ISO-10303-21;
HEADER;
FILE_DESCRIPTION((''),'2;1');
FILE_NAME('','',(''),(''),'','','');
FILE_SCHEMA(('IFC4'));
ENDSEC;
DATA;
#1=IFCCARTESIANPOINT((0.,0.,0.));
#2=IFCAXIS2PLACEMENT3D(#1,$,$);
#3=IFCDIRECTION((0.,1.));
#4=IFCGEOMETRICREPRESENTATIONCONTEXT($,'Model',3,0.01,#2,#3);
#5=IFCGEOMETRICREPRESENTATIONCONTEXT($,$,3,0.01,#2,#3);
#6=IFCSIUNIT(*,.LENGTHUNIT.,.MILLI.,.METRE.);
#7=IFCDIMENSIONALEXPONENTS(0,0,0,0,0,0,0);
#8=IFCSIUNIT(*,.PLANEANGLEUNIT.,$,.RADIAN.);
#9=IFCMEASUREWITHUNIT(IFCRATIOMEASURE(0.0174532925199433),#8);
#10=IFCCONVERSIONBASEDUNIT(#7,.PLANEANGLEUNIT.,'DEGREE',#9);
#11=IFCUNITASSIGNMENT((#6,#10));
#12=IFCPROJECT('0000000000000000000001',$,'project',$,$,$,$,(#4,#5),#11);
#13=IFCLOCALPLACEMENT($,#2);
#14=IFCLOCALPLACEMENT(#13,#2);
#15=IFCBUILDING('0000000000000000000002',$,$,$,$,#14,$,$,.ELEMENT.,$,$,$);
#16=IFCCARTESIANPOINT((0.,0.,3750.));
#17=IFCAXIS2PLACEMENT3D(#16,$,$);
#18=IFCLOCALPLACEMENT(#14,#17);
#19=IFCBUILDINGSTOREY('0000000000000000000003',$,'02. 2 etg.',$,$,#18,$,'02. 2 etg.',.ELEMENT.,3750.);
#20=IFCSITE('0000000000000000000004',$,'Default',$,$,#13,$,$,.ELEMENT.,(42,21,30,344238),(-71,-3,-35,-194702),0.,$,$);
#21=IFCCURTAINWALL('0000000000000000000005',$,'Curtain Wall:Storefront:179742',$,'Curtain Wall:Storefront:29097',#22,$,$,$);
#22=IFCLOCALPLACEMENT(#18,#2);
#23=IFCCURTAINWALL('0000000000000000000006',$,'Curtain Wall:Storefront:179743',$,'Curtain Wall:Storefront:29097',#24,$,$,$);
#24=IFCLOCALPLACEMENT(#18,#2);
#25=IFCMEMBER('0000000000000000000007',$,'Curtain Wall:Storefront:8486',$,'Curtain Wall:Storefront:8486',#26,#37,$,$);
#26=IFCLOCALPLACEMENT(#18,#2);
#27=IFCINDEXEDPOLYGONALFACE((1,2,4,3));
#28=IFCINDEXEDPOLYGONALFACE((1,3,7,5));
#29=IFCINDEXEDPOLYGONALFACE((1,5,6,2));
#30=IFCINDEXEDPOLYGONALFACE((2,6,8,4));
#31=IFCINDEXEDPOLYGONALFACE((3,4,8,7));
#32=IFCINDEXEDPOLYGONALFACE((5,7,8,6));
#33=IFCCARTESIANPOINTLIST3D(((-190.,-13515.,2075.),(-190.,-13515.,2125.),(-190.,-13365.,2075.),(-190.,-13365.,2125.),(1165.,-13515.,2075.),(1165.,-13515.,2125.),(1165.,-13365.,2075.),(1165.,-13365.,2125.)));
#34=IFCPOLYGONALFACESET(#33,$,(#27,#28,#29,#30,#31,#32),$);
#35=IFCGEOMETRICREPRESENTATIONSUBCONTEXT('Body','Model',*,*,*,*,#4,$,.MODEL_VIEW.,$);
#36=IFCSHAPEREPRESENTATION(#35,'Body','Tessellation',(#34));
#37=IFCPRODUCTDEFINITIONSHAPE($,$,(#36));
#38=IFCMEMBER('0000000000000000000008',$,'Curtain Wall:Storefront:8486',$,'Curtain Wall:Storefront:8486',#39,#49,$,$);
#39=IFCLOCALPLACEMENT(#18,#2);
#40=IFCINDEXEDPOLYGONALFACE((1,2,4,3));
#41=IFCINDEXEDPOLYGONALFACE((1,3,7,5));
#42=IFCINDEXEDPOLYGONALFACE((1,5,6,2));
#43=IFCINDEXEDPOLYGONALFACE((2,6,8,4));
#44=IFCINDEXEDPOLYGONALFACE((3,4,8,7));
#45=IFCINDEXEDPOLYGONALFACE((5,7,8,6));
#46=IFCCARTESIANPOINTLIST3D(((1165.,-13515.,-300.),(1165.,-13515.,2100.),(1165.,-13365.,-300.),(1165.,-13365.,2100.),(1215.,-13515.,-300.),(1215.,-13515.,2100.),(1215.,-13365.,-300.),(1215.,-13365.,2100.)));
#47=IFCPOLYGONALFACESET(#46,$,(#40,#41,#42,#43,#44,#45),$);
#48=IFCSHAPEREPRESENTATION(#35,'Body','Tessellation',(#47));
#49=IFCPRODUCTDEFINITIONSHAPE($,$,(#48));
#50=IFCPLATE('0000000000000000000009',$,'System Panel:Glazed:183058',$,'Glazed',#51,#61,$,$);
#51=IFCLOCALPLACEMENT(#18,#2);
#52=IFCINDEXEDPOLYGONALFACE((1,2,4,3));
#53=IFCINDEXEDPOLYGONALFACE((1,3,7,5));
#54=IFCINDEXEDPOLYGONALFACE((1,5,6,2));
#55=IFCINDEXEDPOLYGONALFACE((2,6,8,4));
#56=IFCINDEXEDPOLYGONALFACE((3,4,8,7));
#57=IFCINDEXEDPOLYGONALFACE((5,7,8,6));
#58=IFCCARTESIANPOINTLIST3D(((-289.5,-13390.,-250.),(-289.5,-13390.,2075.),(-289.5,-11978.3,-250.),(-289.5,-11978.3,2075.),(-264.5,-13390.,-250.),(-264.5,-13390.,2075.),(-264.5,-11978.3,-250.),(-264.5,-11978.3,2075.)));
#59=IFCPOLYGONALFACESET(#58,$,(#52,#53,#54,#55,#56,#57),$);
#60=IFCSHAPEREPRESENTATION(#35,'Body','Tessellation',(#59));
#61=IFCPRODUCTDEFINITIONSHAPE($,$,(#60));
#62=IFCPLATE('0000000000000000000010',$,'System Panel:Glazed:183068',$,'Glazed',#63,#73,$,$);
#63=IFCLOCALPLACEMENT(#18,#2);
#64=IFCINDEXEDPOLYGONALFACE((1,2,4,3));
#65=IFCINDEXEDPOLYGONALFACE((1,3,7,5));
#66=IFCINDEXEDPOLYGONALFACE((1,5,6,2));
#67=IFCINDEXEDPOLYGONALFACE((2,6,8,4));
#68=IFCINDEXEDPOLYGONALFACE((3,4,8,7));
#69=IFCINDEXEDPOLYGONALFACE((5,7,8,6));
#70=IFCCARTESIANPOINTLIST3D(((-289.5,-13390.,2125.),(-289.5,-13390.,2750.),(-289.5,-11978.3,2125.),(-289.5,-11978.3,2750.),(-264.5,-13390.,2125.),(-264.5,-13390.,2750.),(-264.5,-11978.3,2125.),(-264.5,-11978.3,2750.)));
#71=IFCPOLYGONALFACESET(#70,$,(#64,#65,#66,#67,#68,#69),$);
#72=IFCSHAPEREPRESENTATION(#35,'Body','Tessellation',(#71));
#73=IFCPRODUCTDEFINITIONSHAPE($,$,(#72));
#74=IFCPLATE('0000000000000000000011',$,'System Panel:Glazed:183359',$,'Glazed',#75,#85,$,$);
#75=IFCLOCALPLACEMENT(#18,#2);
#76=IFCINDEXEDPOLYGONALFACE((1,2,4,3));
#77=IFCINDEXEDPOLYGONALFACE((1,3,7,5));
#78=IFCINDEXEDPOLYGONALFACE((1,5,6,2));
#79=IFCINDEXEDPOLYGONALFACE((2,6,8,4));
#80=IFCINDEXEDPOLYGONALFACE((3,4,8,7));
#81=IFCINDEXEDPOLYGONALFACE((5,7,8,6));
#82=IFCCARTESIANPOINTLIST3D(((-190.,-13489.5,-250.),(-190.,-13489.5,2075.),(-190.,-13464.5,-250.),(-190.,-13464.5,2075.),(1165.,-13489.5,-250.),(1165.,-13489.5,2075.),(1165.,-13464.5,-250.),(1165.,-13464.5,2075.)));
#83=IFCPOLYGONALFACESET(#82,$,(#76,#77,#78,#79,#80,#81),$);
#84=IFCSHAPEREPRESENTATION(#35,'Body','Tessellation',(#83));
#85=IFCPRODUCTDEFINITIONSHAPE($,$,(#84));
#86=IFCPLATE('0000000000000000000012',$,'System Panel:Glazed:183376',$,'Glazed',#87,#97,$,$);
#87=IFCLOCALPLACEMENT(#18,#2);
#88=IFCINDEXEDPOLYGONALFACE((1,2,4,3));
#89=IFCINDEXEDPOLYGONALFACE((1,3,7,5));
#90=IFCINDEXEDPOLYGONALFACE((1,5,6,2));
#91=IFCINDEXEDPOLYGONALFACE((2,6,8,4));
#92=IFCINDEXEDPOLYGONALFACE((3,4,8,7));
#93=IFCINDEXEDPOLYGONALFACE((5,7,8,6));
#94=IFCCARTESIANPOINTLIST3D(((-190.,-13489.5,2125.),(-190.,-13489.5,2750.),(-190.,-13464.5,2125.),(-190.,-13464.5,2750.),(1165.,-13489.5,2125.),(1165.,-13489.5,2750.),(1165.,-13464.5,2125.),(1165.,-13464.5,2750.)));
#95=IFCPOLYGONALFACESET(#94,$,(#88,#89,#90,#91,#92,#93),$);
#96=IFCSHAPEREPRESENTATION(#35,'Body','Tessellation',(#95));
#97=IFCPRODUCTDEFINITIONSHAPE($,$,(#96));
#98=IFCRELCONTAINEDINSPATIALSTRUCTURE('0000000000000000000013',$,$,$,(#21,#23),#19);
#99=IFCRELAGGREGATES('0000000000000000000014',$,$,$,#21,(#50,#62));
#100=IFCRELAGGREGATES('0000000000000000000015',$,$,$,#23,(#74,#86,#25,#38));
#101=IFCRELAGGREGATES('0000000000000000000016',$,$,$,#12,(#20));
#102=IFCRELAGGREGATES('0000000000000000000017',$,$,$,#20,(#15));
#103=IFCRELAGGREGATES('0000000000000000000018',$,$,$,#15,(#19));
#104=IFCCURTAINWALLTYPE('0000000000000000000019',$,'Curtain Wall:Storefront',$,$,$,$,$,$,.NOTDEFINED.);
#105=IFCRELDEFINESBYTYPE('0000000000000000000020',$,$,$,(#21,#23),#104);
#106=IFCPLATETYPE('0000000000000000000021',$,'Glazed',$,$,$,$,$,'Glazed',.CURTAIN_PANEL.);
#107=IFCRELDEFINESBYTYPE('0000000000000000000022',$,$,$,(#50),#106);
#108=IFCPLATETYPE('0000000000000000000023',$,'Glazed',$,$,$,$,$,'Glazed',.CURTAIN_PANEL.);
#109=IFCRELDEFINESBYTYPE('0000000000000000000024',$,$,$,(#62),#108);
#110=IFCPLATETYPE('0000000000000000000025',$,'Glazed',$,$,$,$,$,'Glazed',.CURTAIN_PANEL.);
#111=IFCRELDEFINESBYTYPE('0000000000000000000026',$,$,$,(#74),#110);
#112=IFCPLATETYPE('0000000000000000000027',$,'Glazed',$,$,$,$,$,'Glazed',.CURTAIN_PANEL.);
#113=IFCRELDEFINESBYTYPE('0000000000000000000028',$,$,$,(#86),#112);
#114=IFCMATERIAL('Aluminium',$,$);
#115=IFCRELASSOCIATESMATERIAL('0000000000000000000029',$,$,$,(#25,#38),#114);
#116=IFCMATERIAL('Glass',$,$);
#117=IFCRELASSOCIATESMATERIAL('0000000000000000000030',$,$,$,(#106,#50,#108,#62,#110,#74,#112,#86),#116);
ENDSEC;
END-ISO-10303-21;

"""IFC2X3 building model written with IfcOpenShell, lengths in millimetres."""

from ifc_helpers import new_model, entity, si_unit, converted_unit, direction, frame, frame_2d, origin, origin_2d_with_axis, place, context, subcontext, project, spatial, rectangle, extrude, source, transform, mapped, material, type_object, type_shapes, element, aggregate, save


model = new_model("IFC2X3")

# Units and contexts
model_context = context("Model", 3, precision=0.01, world=origin(), true_north=direction((0.0, 1.0)))
context_of_model = context(None, 3, precision=0.01, world=origin(), true_north=direction((0.0, 1.0)))
body_context = subcontext(model_context, "Body", "Model", "MODEL_VIEW")
ifc_project = project(units=[si_unit("LENGTHUNIT", "METRE", prefix="MILLI"), converted_unit("PLANEANGLEUNIT", "DEGREE", entity("IfcRatioMeasure", 0.0174532925199433), si_unit("PLANEANGLEUNIT", "RADIAN"), dimensions=[0, 0, 0, 0, 0, 0, 0])], contexts=[model_context, context_of_model])

# Site, building, storey
site_placement = place(None, origin())
site = spatial("IfcSite", under=ifc_project, at=site_placement, Name="Default", CompositionType="ELEMENT", RefLatitude=(42, 21, 30, 344238), RefLongitude=(-71, -3, -35, -194702), RefElevation=0.0)
building_placement = place(site_placement, origin())
building = spatial("IfcBuilding", under=site, at=building_placement, CompositionType="ELEMENT")
storey_placement = place(building_placement, frame((0.0, 0.0, 3750.0)))
storey = spatial("IfcBuildingStorey", under=building, at=storey_placement, Name="02. 2 etg.", LongName="02. 2 etg.", CompositionType="ELEMENT", Elevation=3750.0)

# Curtain walls, members
curtain_wall_type = type_object("IfcCurtainWallType", Name="Curtain Wall:Storefront", PredefinedType="NOTDEFINED")
curtain_wall_1_placement = place(storey_placement, frame((0.0, 0.0, -3750.0)))
curtain_wall_1 = element("IfcCurtainWall", 1, at=curtain_wall_1_placement, inside=storey, type_object=curtain_wall_type, Name="Curtain Wall:Storefront:179742", ObjectType="Curtain Wall:Storefront:29097")
ifc_material_1 = material(Name="Aluminium")
curtain_wall_2_placement = place(storey_placement, frame((0.0, 0.0, -3750.0)))
curtain_wall_2 = element("IfcCurtainWall", 2, at=curtain_wall_2_placement, inside=storey, type_object=curtain_wall_type, Name="Curtain Wall:Storefront:179743", ObjectType="Curtain Wall:Storefront:29097")
member_1_placement = place(curtain_wall_2_placement, frame((-190.0, -13515.0, 5825.0)))
member_1 = element("IfcMember", 3, at=member_1_placement, material=ifc_material_1, Name="Curtain Wall:Storefront:8486", ObjectType="Curtain Wall:Storefront:8486", context=body_context, shape_type="SweptSolid", body=[
    extrude(rectangle(XDim=1355.0, YDim=150.0, at=origin_2d_with_axis()), frame((677.5, 75.0, 0.0), z_axis=(0.0, 0.0, 1.0), x_axis=(-1.0, 0.0, 0.0)), (0.0, 0.0, 1.0), 50.0),
])
member_2_placement = place(curtain_wall_2_placement, frame((1165.0, -13515.0, 3450.0)))
member_2 = element("IfcMember", 4, at=member_2_placement, material=ifc_material_1, Name="Curtain Wall:Storefront:8486", ObjectType="Curtain Wall:Storefront:8486", context=body_context, shape_type="SweptSolid", body=[
    extrude(rectangle(XDim=150.0, YDim=50.0, at=origin_2d_with_axis()), frame((25.0, 75.0, 0.0), z_axis=(0.0, 0.0, 1.0), x_axis=(0.0, 1.0, 0.0)), (0.0, 0.0, 1.0), 2400.0),
])

# Plates
ifc_material_2 = material(Name="Glass")
plate_type_1 = type_object("IfcPlateType", Name="Glazed", ElementType="Glazed", PredefinedType="CURTAIN_PANEL", material=ifc_material_2)
shared_shape_1 = source(origin(), body_context, "Body", "SweptSolid", [
    extrude(rectangle(XDim=25.0, YDim=1411.7, at=frame_2d((0.0, 0.0), x_axis=(1.0, 0.0))), frame((705.8, 12.5, 0.0), z_axis=(0.0, 0.0, 1.0), x_axis=(0.0, 1.0, 0.0)), (0.0, 0.0, 1.0), 2325.0),
])
type_shapes(plate_type_1, [shared_shape_1])
plate_1_placement = place(curtain_wall_1_placement, frame((-289.5, -11978.3, 3500.0), z_axis=(0.0, 0.0, 1.0), x_axis=(0.0, -1.0, 0.0)))
plate_1 = element("IfcPlate", 5, at=plate_1_placement, type_object=plate_type_1, material=ifc_material_2, Name="System Panel:Glazed:183058", ObjectType="Glazed", context=body_context, shape_type="MappedRepresentation", body=[
    mapped(shared_shape_1, transform((0.0, 0.0, 0.0), scale=1.0)),
])
plate_type_2 = type_object("IfcPlateType", Name="Glazed", ElementType="Glazed", PredefinedType="CURTAIN_PANEL", material=ifc_material_2)
shared_shape_2 = source(origin(), body_context, "Body", "SweptSolid", [
    extrude(rectangle(XDim=25.0, YDim=1411.7, at=frame_2d((0.0, 0.0), x_axis=(1.0, 0.0))), frame((705.8, 12.5, 0.0), z_axis=(0.0, 0.0, 1.0), x_axis=(0.0, 1.0, 0.0)), (0.0, 0.0, 1.0), 625.0),
])
type_shapes(plate_type_2, [shared_shape_2])
plate_2_placement = place(curtain_wall_1_placement, frame((-289.5, -11978.3, 5875.0), z_axis=(0.0, 0.0, 1.0), x_axis=(0.0, -1.0, 0.0)))
plate_2 = element("IfcPlate", 6, at=plate_2_placement, type_object=plate_type_2, material=ifc_material_2, Name="System Panel:Glazed:183068", ObjectType="Glazed", context=body_context, shape_type="MappedRepresentation", body=[
    mapped(shared_shape_2, transform((0.0, 0.0, 0.0), scale=1.0)),
])
aggregate(curtain_wall_1, [plate_1, plate_2])
plate_type_3 = type_object("IfcPlateType", Name="Glazed", ElementType="Glazed", PredefinedType="CURTAIN_PANEL", material=ifc_material_2)
shared_shape_3 = source(origin(), body_context, "Body", "SweptSolid", [
    extrude(rectangle(XDim=25.0, YDim=1355.0, at=frame_2d((0.0, 0.0), x_axis=(1.0, 0.0))), frame((677.5, 12.5, 0.0), z_axis=(0.0, 0.0, 1.0), x_axis=(0.0, 1.0, 0.0)), (0.0, 0.0, 1.0), 2325.0),
])
type_shapes(plate_type_3, [shared_shape_3])
plate_3_placement = place(curtain_wall_2_placement, frame((-190.0, -13489.5, 3500.0)))
plate_3 = element("IfcPlate", 7, at=plate_3_placement, type_object=plate_type_3, material=ifc_material_2, Name="System Panel:Glazed:183359", ObjectType="Glazed", context=body_context, shape_type="MappedRepresentation", body=[
    mapped(shared_shape_3, transform((0.0, 0.0, 0.0), scale=1.0)),
])
plate_type_4 = type_object("IfcPlateType", Name="Glazed", ElementType="Glazed", PredefinedType="CURTAIN_PANEL", material=ifc_material_2)
shared_shape_4 = source(origin(), body_context, "Body", "SweptSolid", [
    extrude(rectangle(XDim=25.0, YDim=1355.0, at=frame_2d((0.0, 0.0), x_axis=(1.0, 0.0))), frame((677.5, 12.5, 0.0), z_axis=(0.0, 0.0, 1.0), x_axis=(0.0, 1.0, 0.0)), (0.0, 0.0, 1.0), 625.0),
])
type_shapes(plate_type_4, [shared_shape_4])
plate_4_placement = place(curtain_wall_2_placement, frame((-190.0, -13489.5, 5875.0)))
plate_4 = element("IfcPlate", 8, at=plate_4_placement, type_object=plate_type_4, material=ifc_material_2, Name="System Panel:Glazed:183376", ObjectType="Glazed", context=body_context, shape_type="MappedRepresentation", body=[
    mapped(shared_shape_4, transform((0.0, 0.0, 0.0), scale=1.0)),
])
aggregate(curtain_wall_2, [plate_3, plate_4, member_1, member_2])

save(model, "model.ifc")
